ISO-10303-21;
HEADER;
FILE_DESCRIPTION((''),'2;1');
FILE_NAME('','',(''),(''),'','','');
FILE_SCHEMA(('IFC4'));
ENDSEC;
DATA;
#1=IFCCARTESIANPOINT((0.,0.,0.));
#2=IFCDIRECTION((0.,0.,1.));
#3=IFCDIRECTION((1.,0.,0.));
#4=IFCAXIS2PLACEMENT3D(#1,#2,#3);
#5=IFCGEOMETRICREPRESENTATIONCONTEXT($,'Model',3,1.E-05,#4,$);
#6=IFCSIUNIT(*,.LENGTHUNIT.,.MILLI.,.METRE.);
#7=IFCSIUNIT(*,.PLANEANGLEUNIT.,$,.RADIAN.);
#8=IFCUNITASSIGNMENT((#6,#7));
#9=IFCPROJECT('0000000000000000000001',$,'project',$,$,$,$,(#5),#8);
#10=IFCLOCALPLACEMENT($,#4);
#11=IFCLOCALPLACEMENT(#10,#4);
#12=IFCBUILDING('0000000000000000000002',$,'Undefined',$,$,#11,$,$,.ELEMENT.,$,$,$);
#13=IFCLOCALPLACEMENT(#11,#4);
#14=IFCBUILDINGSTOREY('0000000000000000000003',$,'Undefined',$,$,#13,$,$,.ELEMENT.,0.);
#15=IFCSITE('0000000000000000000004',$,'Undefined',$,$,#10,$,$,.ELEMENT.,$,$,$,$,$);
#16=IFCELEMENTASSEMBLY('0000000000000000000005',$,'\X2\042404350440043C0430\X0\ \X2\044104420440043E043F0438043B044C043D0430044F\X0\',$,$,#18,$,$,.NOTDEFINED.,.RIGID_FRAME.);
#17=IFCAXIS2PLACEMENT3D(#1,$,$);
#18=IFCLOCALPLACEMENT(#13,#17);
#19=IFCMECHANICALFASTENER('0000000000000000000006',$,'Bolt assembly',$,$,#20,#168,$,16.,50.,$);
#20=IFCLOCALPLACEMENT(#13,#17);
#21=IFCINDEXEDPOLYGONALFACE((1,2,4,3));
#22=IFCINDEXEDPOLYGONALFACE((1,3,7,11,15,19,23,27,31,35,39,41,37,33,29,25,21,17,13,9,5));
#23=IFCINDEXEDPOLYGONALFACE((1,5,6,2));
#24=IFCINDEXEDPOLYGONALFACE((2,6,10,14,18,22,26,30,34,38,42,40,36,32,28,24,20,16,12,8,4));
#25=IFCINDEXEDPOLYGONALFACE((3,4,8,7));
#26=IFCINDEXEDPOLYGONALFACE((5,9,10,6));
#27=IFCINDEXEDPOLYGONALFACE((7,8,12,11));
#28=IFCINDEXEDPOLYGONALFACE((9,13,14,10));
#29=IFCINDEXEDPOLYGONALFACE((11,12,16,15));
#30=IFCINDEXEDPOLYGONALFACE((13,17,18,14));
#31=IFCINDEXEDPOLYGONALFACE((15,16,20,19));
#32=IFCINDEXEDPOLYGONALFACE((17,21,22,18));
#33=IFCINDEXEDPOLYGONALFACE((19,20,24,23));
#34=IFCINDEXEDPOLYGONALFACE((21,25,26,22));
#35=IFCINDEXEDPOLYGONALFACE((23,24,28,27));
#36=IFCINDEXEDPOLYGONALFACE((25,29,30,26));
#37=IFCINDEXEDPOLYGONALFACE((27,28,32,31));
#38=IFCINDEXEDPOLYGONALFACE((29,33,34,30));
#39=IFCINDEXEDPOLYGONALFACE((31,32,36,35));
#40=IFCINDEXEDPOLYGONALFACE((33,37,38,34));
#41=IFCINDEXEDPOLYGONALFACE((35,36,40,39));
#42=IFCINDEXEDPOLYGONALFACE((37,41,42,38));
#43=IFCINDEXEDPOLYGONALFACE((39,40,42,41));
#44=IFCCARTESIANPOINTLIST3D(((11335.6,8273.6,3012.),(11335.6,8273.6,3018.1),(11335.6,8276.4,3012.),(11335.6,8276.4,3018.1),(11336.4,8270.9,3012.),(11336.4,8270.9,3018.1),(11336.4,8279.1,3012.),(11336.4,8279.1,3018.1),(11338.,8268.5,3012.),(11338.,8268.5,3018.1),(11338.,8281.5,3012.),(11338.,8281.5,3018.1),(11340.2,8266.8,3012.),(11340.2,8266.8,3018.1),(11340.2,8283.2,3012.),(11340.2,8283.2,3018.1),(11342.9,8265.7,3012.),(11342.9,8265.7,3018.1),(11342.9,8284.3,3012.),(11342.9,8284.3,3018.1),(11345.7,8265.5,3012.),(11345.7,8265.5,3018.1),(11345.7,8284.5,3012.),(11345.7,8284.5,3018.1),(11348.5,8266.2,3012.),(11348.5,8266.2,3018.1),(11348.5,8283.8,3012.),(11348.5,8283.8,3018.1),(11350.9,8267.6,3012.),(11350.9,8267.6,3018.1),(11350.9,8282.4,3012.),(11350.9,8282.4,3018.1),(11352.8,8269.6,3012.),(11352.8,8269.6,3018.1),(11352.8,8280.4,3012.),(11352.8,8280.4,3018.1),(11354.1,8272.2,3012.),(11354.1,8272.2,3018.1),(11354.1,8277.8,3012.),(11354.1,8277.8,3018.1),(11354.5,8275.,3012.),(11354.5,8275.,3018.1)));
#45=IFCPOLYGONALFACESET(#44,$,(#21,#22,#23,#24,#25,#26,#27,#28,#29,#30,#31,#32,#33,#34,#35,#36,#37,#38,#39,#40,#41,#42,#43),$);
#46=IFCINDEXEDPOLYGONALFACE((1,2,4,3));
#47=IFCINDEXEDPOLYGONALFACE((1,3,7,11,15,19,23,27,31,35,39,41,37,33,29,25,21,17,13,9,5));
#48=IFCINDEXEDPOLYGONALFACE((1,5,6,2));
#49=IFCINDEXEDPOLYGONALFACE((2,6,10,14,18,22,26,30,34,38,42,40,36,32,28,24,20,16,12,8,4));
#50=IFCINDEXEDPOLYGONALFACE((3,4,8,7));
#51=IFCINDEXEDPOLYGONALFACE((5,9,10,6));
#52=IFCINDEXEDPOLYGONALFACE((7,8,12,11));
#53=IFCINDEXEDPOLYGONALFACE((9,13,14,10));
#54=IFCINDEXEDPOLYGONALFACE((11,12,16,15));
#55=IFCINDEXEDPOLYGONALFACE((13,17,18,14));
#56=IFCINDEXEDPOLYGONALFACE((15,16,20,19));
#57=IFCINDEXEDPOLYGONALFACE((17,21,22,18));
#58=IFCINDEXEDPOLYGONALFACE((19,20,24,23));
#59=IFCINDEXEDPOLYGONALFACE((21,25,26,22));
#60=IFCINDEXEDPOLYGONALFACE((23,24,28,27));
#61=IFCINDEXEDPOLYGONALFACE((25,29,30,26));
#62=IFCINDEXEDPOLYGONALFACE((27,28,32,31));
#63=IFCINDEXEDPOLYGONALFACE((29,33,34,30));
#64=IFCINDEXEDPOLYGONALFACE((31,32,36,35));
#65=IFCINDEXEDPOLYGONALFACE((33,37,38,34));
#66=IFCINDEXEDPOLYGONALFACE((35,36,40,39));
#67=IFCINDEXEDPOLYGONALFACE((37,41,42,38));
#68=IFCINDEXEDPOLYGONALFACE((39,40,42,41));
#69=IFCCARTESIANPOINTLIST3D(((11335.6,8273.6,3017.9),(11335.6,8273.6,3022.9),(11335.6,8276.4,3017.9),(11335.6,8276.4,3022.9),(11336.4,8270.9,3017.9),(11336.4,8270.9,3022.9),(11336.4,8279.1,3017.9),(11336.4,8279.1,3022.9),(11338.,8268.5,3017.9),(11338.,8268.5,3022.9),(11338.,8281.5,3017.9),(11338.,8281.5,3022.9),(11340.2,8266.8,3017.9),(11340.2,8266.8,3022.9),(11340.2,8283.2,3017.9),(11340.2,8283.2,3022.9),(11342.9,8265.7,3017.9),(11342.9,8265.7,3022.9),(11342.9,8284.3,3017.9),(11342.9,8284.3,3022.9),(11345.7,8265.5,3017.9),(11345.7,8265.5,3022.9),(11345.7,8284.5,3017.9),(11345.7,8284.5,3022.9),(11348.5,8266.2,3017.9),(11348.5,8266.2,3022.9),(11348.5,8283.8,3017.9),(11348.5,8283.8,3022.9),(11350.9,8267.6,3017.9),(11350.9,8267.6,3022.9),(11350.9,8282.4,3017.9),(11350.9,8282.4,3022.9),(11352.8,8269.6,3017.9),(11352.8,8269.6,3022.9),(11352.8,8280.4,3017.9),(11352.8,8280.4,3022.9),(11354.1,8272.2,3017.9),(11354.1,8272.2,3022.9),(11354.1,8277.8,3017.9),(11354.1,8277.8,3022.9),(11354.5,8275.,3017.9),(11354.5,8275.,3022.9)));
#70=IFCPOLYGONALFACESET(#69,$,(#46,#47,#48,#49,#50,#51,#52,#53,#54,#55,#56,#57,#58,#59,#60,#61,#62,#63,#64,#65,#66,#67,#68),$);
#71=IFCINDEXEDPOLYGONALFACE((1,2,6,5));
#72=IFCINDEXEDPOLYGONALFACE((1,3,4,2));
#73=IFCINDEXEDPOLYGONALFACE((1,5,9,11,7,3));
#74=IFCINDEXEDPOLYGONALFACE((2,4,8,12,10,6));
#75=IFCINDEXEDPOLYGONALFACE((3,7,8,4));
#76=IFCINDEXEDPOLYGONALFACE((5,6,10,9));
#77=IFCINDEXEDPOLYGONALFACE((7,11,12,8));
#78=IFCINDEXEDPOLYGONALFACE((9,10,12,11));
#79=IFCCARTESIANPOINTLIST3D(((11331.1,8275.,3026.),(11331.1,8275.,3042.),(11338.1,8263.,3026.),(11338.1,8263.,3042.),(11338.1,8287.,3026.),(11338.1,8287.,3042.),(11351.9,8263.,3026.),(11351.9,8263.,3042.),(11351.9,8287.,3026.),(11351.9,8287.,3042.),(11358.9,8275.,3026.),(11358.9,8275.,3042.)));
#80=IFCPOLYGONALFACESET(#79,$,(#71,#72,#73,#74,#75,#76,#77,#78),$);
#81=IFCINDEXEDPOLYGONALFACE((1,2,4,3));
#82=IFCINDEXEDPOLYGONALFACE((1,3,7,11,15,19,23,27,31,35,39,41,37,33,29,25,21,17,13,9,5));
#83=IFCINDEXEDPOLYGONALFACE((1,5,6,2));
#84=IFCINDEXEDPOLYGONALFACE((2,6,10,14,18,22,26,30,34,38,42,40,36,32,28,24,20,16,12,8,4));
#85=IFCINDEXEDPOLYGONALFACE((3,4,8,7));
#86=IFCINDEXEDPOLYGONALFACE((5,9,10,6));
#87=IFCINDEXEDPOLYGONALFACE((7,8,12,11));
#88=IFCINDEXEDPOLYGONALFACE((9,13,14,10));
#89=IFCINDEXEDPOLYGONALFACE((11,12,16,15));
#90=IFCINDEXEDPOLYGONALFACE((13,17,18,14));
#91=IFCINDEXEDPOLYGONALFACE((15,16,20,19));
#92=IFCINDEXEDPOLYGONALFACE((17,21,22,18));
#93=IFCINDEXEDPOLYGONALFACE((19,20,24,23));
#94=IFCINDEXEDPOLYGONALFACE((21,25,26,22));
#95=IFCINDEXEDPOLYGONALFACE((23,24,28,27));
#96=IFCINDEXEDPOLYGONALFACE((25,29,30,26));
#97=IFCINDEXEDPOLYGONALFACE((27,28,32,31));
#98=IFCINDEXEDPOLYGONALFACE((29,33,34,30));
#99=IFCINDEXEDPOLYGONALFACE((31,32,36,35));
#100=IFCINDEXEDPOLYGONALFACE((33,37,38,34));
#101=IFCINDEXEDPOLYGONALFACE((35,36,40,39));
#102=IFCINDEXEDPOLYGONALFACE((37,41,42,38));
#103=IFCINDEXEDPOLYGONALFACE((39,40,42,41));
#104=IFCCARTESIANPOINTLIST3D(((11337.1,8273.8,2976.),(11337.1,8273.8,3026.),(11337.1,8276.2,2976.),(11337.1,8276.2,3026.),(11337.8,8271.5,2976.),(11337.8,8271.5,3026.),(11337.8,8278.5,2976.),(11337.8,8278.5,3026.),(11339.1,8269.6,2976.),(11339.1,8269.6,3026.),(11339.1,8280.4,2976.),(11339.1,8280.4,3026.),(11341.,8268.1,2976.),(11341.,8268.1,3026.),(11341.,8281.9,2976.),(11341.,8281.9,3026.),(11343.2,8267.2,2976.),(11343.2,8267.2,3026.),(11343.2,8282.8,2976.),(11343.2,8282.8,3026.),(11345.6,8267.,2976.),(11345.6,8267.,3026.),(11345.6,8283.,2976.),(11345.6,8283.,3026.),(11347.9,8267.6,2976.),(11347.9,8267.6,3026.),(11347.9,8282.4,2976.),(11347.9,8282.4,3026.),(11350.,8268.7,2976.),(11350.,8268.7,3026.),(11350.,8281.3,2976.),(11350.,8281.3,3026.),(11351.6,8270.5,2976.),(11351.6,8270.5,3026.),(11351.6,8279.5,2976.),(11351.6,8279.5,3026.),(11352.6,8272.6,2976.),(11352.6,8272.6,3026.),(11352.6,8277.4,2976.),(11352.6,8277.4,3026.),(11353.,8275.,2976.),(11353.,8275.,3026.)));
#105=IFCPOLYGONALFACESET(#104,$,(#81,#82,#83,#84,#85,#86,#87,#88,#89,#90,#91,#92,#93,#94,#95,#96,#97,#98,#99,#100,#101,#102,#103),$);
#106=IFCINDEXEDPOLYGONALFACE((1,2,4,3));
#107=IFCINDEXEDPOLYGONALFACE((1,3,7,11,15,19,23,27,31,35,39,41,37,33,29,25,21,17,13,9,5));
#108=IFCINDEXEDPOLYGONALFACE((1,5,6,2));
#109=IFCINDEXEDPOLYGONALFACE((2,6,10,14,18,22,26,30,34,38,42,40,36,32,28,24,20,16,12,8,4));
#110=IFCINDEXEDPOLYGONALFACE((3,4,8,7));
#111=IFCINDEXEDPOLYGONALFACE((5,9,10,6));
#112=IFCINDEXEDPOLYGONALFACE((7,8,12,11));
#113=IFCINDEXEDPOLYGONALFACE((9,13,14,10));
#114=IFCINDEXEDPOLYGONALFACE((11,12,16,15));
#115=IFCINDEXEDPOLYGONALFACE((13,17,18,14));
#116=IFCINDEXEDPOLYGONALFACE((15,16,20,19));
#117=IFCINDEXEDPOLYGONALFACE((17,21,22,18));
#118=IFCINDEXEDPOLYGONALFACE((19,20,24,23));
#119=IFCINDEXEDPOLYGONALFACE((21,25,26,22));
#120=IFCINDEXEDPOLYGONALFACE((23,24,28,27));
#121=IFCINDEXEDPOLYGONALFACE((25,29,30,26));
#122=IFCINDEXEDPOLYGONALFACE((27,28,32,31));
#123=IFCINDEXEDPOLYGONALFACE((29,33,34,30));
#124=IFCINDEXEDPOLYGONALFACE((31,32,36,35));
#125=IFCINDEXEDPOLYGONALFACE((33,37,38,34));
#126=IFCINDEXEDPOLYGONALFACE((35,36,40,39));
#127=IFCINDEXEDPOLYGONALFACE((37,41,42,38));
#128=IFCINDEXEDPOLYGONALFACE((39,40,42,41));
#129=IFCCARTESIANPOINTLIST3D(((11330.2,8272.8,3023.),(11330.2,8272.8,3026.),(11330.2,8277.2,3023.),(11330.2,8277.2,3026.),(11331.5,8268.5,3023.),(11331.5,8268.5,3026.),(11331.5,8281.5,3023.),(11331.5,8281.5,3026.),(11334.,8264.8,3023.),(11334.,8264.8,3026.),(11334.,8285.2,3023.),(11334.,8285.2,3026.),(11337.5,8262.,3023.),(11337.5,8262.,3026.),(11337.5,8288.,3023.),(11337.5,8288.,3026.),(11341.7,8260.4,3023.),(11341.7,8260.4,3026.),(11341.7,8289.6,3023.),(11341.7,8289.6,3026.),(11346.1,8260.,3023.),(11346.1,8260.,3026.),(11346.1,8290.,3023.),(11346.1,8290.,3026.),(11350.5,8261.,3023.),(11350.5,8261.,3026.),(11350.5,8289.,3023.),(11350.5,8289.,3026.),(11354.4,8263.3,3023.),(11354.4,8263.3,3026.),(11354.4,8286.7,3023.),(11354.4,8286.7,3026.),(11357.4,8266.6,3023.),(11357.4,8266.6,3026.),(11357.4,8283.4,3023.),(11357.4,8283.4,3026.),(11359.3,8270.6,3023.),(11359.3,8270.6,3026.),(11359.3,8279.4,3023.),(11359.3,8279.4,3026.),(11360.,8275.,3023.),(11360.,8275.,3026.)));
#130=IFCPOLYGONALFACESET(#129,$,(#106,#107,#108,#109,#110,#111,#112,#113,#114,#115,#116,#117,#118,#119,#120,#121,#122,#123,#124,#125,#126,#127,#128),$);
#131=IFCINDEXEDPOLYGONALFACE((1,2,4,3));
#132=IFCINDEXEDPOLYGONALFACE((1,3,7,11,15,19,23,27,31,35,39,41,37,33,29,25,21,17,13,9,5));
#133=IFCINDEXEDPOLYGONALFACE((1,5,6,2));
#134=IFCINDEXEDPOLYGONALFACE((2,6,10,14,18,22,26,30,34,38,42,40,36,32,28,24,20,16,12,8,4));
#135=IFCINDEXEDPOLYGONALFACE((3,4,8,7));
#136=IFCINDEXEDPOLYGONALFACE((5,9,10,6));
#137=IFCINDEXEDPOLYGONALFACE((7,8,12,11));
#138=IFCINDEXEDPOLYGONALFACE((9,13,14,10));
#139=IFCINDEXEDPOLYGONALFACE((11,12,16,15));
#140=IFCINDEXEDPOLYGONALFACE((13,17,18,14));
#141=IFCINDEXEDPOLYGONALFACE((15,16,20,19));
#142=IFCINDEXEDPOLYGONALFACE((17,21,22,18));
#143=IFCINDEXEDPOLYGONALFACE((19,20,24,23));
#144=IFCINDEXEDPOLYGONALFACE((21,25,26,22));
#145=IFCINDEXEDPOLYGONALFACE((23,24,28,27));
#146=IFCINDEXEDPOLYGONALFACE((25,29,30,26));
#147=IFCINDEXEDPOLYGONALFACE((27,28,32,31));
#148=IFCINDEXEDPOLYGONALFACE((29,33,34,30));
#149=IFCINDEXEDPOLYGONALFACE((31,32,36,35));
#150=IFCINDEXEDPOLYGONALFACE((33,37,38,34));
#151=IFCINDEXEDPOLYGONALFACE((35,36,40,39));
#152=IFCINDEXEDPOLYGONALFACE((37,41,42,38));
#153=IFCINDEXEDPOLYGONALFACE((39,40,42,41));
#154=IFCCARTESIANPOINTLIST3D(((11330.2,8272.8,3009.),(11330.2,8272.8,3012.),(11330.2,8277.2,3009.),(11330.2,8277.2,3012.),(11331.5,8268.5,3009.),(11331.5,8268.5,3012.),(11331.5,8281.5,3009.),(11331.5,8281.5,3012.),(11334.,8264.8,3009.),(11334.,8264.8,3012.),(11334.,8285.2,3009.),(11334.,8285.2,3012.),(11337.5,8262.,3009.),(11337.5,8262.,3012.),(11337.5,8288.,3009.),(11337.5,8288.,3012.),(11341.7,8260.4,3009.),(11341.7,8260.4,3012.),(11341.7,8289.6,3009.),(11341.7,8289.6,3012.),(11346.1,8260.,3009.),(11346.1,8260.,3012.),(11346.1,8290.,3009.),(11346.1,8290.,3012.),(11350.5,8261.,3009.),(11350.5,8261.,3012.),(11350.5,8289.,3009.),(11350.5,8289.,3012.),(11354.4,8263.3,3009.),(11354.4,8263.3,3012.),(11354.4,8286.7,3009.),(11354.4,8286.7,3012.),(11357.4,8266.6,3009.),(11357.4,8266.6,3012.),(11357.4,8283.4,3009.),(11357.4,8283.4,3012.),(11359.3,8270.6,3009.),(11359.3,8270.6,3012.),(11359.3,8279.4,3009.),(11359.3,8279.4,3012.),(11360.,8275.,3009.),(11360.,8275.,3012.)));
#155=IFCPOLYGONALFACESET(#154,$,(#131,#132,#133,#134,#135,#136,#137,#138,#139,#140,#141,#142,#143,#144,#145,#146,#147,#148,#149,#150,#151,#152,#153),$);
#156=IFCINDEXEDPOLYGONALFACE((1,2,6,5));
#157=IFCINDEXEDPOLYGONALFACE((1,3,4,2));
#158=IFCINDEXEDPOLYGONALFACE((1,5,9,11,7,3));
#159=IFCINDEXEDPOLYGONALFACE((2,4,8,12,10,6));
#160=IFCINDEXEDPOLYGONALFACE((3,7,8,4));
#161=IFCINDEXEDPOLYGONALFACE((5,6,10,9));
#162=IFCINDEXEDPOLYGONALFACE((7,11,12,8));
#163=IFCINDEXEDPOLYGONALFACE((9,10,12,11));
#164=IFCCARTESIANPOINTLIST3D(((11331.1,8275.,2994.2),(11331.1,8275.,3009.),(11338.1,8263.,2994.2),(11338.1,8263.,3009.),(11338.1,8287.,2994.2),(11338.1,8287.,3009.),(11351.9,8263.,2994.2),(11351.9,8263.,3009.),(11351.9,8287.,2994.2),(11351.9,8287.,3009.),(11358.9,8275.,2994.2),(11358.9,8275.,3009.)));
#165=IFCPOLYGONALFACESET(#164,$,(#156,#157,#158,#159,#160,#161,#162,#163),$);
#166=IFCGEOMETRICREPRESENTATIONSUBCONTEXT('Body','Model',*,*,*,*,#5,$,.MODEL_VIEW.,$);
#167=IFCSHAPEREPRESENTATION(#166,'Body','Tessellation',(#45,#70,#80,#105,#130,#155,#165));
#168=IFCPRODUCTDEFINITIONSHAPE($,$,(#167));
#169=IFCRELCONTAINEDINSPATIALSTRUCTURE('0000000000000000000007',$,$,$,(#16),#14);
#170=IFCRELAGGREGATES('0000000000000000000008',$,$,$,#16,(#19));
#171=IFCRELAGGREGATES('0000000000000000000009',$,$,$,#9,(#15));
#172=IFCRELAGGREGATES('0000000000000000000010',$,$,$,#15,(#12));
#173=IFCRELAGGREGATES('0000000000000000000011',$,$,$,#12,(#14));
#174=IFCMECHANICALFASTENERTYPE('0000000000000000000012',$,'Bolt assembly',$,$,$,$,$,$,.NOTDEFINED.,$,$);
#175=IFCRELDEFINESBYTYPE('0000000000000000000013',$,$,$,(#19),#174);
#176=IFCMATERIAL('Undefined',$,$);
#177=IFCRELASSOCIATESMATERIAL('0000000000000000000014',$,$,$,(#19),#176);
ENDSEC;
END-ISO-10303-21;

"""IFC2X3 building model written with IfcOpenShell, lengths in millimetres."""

from ifc_helpers import new_model, si_unit, frame, origin_with_axes, origin_2d_with_axis, place, context, subcontext, project, spatial, polyline, circle, outline, extrude, source, transform, mapped, material, type_object, element, aggregate, save


model = new_model("IFC2X3")

# Units and contexts
model_context = context("Model", 3, precision=1e-05, world=origin_with_axes())
body_context = subcontext(model_context, "Body", "Model", "MODEL_VIEW")
ifc_project = project(units=[si_unit("LENGTHUNIT", "METRE", prefix="MILLI"), si_unit("PLANEANGLEUNIT", "RADIAN")], contexts=[model_context])

# Site, building, storey
site_placement = place(None, origin_with_axes())
site = spatial("IfcSite", under=ifc_project, at=site_placement, Name="Undefined", CompositionType="ELEMENT")
building_placement = place(site_placement, origin_with_axes())
building = spatial("IfcBuilding", under=site, at=building_placement, Name="Undefined", CompositionType="ELEMENT")
storey_placement = place(building_placement, origin_with_axes())
storey = spatial("IfcBuildingStorey", under=building, at=storey_placement, Name="Undefined", CompositionType="ELEMENT", Elevation=0.0)

# Element assembly
assembly_1_placement = place(storey_placement, origin_with_axes())
assembly_1 = element("IfcElementAssembly", 1, at=assembly_1_placement, inside=storey, Name="Ферма стропильная", AssemblyPlace="NOTDEFINED", PredefinedType="RIGID_FRAME")

# Mechanical fastener
ifc_material_1 = material(Name="Undefined")
mechanical_fastener_type = type_object("IfcMechanicalFastenerType", Name="Bolt assembly")
shared_shape_1 = source(origin_with_axes(), body_context, "Body", "SweptSolid", [
    extrude(circle(Radius=9.5, at=origin_2d_with_axis()), frame((0.0, -0.1, 0.0), z_axis=(0.0, 1.0, 0.0), x_axis=(1.0, 0.0, 0.0)), (0.0, 0.0, 1.0), 6.1),
    extrude(circle(Radius=9.5, at=origin_2d_with_axis()), frame((0.0, -4.9, 0.0), z_axis=(0.0, 1.0, 0.0), x_axis=(1.0, 0.0, 0.0)), (0.0, 0.0, 1.0), 5.0),
    extrude(outline(polyline([(13.9, 0.0), (6.9, 12.0), (-6.9, 12.0), (-13.9, 0.0), (-6.9, -12.0), (6.9, -12.0), (13.9, 0.0)])), frame((0.0, -24.0, 0.0), z_axis=(0.0, 1.0, 0.0), x_axis=(1.0, 0.0, 0.0)), (0.0, 0.0, 1.0), 16.0),
    extrude(circle(Radius=8.0, at=origin_2d_with_axis()), frame((0.0, -8.0, 0.0), z_axis=(0.0, 1.0, 0.0), x_axis=(1.0, 0.0, 0.0)), (0.0, 0.0, 1.0), 50.0),
    extrude(circle(Radius=15.0, at=origin_2d_with_axis()), frame((0.0, -8.0, 0.0), z_axis=(0.0, 1.0, 0.0), x_axis=(1.0, 0.0, 0.0)), (0.0, 0.0, 1.0), 3.0),
    extrude(circle(Radius=15.0, at=origin_2d_with_axis()), frame((0.0, 6.0, 0.0), z_axis=(0.0, 1.0, 0.0), x_axis=(1.0, 0.0, 0.0)), (0.0, 0.0, 1.0), 3.0),
    extrude(outline(polyline([(13.9, 0.0), (6.9, 12.0), (-6.9, 12.0), (-13.9, 0.0), (-6.9, -12.0), (6.9, -12.0), (13.9, 0.0)])), frame((0.0, 9.0, 0.0), z_axis=(0.0, 1.0, 0.0), x_axis=(1.0, 0.0, 0.0)), (0.0, 0.0, 1.0), 14.8),
])
mechanical_fastener_1_placement = place(assembly_1_placement, frame((11345.0, 8275.0, 3018.0), z_axis=(0.0, 1.0, 0.0), x_axis=(1.0, 0.0, 0.0)))
mechanical_fastener_1 = element("IfcMechanicalFastener", 2, at=mechanical_fastener_1_placement, type_object=mechanical_fastener_type, material=ifc_material_1, Name="Bolt assembly", NominalDiameter=16.0, NominalLength=50.0, context=body_context, shape_type="MappedRepresentation", body=[
    mapped(shared_shape_1, transform((0.0, 0.0, 0.0))),
])
aggregate(assembly_1, [mechanical_fastener_1])

save(model, "model.ifc")
